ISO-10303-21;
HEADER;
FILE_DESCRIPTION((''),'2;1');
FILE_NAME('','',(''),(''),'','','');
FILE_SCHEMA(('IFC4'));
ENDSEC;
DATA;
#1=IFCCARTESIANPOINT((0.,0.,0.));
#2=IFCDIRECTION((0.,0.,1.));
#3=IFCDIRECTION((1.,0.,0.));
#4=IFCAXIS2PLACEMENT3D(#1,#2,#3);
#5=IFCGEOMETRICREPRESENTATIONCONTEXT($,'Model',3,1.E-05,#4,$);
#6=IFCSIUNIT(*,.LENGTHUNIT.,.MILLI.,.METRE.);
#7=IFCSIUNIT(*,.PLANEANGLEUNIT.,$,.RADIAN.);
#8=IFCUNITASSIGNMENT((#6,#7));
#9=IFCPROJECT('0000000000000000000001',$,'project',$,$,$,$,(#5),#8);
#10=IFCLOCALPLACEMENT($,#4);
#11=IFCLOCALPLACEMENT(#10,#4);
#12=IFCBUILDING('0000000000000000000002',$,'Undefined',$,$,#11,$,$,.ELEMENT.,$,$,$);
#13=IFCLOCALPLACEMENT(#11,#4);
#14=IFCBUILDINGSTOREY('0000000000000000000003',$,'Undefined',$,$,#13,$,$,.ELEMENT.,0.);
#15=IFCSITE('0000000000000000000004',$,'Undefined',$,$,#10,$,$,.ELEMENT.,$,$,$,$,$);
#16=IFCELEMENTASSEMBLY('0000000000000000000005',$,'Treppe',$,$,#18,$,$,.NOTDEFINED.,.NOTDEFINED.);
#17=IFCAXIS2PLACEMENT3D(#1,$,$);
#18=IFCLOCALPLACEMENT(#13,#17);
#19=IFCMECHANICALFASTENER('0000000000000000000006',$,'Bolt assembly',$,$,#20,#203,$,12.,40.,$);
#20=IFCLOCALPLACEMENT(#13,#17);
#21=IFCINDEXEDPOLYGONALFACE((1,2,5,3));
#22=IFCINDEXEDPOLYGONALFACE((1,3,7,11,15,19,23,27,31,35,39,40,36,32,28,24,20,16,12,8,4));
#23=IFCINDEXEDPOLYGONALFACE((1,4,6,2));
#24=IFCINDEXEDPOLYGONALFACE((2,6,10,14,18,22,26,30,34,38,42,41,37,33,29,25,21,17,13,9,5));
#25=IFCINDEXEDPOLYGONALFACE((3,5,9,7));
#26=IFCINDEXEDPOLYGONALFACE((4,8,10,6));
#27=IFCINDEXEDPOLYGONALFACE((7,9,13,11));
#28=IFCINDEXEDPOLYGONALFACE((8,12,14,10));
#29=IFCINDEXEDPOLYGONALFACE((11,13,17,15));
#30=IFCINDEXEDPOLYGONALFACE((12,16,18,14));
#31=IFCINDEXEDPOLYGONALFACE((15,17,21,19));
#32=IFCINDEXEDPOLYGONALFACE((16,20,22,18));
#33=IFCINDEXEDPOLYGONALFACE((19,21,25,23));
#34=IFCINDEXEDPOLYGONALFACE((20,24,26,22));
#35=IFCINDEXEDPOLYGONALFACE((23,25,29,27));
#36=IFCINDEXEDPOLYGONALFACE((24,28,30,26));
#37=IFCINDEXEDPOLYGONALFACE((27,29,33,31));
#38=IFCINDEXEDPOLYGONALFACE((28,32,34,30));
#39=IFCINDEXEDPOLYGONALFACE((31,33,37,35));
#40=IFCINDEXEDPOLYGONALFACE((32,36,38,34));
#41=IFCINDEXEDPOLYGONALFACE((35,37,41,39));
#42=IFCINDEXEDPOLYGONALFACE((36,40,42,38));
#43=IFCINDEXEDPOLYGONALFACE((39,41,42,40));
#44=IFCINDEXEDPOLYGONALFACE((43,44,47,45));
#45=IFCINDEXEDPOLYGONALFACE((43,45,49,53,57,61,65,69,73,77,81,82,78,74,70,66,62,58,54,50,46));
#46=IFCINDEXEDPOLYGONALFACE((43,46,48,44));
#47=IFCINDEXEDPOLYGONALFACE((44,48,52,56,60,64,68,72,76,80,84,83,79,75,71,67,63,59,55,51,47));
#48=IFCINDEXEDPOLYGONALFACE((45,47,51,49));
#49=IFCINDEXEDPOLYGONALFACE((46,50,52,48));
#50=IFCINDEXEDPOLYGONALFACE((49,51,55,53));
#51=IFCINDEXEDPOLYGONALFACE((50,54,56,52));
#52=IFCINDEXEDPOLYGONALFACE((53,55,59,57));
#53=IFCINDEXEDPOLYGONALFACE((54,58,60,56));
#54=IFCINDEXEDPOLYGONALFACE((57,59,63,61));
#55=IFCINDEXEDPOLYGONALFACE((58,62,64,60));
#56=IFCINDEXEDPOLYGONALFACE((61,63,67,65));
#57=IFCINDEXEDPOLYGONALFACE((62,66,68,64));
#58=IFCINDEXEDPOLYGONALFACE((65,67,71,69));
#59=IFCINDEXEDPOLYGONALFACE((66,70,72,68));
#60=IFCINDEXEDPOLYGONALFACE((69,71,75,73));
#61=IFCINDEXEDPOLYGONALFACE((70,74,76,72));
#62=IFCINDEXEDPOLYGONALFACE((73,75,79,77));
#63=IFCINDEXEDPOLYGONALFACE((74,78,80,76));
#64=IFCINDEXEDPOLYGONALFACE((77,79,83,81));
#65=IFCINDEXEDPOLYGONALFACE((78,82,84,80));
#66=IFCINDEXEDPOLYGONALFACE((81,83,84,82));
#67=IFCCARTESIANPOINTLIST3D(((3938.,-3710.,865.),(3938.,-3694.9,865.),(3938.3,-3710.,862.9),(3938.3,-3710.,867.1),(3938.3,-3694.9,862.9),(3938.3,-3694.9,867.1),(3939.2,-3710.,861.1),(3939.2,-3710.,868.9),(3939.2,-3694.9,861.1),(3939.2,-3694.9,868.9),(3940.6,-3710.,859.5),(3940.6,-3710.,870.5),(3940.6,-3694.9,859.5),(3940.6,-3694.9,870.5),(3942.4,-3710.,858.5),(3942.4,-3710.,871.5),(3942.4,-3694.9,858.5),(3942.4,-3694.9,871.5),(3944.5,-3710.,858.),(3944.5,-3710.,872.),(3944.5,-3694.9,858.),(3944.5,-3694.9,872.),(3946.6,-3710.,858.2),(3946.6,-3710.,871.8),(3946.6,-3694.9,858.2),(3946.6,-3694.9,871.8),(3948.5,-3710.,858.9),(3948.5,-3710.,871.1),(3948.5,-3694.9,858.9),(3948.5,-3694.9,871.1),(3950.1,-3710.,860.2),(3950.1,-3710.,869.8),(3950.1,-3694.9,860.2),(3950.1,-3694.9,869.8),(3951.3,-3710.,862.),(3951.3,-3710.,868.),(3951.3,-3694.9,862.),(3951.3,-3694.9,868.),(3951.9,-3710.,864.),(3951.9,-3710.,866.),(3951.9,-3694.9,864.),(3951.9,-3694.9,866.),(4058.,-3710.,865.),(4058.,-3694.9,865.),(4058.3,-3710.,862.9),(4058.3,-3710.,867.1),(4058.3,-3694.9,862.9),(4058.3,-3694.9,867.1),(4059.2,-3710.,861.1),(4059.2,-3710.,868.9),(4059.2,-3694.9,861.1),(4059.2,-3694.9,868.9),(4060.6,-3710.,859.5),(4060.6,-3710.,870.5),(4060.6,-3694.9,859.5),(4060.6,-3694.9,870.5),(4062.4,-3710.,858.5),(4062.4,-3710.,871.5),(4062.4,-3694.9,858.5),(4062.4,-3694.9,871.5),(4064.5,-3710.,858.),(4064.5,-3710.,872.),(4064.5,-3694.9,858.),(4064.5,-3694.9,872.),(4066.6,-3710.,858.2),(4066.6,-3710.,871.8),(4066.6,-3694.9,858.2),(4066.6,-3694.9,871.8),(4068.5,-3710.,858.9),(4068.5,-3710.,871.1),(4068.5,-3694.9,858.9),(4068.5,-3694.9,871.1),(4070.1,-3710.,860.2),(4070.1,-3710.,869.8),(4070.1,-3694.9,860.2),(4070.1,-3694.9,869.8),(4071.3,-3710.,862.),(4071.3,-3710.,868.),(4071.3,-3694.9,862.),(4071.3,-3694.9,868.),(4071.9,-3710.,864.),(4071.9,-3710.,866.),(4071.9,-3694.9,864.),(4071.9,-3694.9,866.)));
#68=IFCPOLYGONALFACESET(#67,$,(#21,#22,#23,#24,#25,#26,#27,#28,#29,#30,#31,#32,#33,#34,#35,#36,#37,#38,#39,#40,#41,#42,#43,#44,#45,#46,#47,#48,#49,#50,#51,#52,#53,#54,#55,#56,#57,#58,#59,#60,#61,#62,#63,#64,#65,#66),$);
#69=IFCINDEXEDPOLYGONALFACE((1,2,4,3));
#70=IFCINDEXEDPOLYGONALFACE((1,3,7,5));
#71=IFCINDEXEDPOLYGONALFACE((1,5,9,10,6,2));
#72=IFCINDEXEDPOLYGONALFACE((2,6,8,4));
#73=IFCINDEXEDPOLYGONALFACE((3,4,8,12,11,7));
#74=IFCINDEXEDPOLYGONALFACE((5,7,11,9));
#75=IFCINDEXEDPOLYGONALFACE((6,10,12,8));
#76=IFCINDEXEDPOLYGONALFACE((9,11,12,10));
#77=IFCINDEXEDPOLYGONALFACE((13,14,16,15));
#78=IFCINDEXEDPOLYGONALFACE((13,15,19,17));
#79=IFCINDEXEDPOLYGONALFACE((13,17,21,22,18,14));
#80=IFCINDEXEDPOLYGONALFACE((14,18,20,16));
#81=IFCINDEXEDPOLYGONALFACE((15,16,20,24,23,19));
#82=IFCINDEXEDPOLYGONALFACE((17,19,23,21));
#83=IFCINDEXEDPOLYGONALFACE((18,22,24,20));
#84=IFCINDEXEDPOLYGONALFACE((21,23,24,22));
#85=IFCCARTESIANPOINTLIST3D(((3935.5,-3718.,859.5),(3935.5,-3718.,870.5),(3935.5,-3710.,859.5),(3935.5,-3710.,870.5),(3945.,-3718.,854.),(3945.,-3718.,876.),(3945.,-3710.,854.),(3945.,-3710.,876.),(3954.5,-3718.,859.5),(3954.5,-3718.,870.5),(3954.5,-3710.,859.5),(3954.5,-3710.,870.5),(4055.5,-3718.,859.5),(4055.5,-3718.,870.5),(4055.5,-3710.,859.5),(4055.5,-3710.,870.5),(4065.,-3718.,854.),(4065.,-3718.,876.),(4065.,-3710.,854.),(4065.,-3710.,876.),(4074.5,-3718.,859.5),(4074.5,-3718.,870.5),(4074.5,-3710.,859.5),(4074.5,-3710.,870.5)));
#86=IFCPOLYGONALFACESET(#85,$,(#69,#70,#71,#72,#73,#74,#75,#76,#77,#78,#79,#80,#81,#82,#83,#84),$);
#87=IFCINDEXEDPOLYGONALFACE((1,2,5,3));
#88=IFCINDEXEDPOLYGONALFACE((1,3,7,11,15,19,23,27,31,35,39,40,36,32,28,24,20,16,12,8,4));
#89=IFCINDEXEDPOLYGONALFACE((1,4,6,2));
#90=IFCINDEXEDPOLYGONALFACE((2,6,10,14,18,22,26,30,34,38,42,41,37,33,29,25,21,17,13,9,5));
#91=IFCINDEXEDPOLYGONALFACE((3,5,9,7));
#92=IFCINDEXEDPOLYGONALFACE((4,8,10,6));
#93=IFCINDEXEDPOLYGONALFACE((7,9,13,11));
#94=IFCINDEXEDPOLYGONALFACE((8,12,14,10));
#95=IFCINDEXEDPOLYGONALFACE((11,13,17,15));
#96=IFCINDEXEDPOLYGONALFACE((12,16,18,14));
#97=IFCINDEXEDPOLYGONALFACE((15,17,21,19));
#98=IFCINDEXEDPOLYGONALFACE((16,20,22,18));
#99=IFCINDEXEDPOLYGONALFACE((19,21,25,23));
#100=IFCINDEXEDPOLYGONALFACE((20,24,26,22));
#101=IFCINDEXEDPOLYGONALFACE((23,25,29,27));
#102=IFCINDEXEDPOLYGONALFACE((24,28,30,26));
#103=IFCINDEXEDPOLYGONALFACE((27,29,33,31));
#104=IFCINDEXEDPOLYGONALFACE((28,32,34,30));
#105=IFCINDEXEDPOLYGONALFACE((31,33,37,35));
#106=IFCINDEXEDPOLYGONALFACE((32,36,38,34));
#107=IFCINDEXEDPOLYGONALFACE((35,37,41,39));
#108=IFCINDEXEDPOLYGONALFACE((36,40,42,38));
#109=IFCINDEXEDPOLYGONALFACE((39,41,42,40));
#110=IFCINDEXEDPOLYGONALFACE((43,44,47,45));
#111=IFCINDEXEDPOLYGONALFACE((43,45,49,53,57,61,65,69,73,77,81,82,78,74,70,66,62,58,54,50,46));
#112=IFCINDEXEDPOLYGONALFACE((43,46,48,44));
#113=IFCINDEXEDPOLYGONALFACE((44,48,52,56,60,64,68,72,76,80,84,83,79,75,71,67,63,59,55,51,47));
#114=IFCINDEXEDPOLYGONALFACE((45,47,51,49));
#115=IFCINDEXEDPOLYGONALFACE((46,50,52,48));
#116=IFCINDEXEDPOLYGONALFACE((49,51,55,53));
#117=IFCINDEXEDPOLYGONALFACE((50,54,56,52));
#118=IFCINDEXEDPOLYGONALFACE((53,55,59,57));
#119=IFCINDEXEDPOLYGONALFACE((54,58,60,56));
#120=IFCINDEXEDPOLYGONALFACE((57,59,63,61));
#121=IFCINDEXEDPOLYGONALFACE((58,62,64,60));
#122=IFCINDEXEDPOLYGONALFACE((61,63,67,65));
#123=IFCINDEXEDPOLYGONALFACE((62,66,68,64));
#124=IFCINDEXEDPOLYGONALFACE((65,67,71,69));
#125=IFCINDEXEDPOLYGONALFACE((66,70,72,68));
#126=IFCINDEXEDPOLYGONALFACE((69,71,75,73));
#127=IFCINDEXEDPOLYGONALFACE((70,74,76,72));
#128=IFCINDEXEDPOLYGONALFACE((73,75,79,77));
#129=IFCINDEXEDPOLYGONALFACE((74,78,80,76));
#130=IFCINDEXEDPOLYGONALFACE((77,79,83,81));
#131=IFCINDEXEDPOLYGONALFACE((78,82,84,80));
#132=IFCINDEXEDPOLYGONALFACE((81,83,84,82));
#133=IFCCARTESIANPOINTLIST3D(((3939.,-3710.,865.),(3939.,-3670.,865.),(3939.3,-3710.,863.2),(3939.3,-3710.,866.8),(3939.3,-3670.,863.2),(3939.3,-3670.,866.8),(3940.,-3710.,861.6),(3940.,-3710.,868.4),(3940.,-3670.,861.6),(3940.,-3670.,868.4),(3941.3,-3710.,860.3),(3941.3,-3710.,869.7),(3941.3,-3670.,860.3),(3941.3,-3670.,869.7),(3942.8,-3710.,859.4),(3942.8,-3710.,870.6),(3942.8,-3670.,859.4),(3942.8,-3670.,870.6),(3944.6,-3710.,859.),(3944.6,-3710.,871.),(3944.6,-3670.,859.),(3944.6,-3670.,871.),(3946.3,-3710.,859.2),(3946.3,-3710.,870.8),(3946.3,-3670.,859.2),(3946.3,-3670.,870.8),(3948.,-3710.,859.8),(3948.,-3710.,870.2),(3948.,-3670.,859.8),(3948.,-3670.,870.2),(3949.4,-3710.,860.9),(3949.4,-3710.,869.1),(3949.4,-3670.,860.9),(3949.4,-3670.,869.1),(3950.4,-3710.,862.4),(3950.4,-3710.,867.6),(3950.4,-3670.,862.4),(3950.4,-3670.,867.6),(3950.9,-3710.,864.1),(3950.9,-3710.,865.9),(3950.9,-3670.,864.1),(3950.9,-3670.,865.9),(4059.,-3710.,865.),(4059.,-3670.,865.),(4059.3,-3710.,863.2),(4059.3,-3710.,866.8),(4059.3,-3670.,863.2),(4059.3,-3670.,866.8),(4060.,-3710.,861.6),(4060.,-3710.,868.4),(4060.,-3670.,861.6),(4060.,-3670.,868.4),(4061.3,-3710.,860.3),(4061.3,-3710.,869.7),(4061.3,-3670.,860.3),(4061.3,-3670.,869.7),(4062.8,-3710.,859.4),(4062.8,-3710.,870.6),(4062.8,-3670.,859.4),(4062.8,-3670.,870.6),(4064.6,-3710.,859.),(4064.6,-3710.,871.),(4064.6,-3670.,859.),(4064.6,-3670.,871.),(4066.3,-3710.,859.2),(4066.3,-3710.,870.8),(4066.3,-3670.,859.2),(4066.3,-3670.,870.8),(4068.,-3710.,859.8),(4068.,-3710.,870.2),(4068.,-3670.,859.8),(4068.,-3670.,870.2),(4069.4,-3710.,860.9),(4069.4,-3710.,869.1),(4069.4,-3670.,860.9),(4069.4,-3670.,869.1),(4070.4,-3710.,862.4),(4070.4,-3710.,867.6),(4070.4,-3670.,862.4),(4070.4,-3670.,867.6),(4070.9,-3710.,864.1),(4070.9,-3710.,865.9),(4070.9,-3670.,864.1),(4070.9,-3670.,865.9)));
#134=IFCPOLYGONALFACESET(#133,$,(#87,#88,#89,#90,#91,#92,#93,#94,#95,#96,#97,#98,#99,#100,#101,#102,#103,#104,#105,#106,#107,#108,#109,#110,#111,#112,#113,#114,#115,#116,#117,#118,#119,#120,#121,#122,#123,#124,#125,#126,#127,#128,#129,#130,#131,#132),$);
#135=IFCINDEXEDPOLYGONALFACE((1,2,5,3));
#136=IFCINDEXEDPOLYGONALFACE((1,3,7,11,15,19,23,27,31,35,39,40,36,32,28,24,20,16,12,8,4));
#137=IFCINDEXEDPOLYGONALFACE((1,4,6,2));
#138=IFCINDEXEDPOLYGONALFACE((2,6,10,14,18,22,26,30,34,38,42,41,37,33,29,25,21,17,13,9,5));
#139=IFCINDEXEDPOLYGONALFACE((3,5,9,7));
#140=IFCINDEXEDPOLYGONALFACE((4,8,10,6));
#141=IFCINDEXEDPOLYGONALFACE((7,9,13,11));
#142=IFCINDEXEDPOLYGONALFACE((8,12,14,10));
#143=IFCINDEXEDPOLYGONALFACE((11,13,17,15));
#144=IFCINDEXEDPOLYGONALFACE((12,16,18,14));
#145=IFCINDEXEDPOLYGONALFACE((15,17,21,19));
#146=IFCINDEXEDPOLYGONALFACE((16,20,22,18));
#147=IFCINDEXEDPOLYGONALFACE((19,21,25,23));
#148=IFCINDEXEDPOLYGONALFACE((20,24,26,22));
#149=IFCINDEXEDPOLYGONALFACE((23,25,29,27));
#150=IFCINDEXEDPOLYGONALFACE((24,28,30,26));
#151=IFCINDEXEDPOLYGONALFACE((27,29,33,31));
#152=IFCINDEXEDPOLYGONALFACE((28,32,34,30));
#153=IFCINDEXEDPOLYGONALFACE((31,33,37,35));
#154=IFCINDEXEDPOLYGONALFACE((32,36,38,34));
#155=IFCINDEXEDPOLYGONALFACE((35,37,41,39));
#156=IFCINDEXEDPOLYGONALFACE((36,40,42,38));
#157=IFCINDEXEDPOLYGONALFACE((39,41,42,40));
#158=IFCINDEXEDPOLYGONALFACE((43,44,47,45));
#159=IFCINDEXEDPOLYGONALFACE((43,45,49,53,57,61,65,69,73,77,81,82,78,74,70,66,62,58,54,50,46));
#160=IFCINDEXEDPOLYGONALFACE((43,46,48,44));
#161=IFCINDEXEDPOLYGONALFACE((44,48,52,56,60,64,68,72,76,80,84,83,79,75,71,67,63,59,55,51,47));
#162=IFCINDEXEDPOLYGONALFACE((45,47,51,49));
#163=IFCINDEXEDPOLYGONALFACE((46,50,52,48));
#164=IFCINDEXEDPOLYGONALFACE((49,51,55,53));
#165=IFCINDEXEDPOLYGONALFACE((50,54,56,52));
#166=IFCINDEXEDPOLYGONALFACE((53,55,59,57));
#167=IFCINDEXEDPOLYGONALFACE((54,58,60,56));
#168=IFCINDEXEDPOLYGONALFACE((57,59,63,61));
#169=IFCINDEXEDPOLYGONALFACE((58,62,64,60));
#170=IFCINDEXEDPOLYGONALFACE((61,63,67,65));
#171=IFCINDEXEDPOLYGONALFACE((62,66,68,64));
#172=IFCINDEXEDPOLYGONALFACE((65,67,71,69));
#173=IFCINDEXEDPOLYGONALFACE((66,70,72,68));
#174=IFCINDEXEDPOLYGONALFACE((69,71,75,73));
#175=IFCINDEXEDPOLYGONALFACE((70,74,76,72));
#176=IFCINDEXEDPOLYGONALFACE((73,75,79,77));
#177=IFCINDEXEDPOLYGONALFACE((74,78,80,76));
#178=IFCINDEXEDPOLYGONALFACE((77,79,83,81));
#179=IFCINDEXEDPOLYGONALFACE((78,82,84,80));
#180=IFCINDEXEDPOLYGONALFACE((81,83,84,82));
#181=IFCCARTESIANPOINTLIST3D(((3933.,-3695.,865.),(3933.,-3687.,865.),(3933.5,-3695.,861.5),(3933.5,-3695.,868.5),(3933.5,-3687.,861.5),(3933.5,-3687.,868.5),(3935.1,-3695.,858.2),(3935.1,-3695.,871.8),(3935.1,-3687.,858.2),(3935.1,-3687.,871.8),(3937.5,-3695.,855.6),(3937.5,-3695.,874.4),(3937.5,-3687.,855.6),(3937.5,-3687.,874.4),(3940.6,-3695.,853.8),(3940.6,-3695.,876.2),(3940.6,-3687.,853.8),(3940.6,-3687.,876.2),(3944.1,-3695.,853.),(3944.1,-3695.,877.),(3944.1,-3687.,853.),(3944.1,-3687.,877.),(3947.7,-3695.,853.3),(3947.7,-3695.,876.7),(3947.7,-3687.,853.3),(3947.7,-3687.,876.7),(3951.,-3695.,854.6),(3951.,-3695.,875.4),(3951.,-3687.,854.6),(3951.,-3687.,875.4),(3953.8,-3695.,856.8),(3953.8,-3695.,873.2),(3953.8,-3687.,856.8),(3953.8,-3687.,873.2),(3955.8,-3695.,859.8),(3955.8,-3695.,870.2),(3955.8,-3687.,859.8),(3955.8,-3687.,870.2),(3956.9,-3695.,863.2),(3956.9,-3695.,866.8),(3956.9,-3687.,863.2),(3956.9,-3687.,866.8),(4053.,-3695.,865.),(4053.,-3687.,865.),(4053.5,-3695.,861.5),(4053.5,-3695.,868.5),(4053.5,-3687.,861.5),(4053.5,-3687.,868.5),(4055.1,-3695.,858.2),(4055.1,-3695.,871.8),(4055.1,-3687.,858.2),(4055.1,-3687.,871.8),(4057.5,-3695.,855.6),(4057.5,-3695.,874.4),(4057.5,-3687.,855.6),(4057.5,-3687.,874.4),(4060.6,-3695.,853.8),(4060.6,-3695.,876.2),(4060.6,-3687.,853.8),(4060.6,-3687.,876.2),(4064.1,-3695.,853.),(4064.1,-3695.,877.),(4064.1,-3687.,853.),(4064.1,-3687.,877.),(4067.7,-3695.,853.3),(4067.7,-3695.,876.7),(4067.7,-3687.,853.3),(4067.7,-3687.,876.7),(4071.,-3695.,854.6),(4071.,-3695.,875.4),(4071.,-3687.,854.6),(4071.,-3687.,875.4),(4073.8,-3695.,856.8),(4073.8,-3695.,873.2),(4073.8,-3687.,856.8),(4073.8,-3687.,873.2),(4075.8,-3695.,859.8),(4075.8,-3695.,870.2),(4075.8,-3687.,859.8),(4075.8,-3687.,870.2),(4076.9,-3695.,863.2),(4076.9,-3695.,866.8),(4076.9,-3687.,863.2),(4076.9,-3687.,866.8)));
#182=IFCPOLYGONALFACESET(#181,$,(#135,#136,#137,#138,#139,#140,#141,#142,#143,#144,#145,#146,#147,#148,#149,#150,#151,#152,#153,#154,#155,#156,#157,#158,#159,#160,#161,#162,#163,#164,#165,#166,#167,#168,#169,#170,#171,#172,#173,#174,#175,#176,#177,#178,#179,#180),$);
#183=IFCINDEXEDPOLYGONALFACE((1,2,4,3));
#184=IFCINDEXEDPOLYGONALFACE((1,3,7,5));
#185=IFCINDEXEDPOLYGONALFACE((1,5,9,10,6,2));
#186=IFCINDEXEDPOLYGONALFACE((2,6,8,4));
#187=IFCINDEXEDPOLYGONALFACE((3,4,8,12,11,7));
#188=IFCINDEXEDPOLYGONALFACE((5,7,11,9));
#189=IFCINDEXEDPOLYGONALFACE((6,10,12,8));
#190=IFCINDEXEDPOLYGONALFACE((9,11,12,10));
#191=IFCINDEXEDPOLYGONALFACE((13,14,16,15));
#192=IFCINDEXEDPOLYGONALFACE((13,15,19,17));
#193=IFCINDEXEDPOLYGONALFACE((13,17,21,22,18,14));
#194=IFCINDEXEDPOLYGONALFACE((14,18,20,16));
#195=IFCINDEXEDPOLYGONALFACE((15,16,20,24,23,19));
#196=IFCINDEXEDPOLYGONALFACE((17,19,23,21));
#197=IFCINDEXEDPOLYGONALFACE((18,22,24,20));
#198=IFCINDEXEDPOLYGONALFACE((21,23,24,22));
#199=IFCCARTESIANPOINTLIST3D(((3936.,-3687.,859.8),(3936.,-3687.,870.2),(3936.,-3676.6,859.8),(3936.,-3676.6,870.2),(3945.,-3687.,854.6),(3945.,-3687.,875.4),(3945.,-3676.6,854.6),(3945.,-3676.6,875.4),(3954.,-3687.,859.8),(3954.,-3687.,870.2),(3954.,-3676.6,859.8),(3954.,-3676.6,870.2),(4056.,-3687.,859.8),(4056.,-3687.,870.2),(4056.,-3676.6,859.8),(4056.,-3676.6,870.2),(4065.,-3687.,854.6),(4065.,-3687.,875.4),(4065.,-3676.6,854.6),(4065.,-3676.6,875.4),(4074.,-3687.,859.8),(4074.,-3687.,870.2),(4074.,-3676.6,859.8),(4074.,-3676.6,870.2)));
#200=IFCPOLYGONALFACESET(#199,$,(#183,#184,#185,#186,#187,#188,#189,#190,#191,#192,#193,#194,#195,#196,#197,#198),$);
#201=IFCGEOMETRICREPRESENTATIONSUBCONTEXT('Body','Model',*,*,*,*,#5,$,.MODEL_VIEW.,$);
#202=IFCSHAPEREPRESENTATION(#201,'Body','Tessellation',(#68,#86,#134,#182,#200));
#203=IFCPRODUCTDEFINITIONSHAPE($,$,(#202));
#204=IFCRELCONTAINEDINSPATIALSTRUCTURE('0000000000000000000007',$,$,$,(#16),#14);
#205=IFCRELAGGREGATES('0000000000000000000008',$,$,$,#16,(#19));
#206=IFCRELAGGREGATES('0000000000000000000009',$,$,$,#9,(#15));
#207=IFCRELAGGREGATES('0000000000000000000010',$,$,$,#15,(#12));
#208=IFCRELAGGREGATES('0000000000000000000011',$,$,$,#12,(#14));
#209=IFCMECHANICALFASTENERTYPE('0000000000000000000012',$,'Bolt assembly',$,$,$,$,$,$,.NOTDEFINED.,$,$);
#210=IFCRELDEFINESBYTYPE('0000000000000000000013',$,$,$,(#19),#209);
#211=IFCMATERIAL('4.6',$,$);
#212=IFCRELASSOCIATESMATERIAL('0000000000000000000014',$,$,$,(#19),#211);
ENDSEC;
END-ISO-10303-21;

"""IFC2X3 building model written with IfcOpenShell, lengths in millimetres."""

from ifc_helpers import new_model, si_unit, frame, origin_with_axes, origin_2d_with_axis, place, context, subcontext, project, spatial, polyline, circle, outline, extrude, source, transform, mapped, material, type_object, element, aggregate, save


model = new_model("IFC2X3")

# Units and contexts
model_context = context("Model", 3, precision=1e-05, world=origin_with_axes())
body_context = subcontext(model_context, "Body", "Model", "MODEL_VIEW")
ifc_project = project(units=[si_unit("LENGTHUNIT", "METRE", prefix="MILLI"), si_unit("PLANEANGLEUNIT", "RADIAN")], contexts=[model_context])

# Site, building, storey
site_placement = place(None, origin_with_axes())
site = spatial("IfcSite", under=ifc_project, at=site_placement, Name="Undefined", CompositionType="ELEMENT")
building_placement = place(site_placement, origin_with_axes())
building = spatial("IfcBuilding", under=site, at=building_placement, Name="Undefined", CompositionType="ELEMENT")
storey_placement = place(building_placement, origin_with_axes())
storey = spatial("IfcBuildingStorey", under=building, at=storey_placement, Name="Undefined", CompositionType="ELEMENT", Elevation=0.0)

# Element assembly, mechanical fastener
assembly_1_placement = place(storey_placement, origin_with_axes())
assembly_1 = element("IfcElementAssembly", 1, at=assembly_1_placement, inside=storey, Name="Treppe", AssemblyPlace="NOTDEFINED", PredefinedType="NOTDEFINED")
ifc_material_1 = material(Name="4.6")
mechanical_fastener_type = type_object("IfcMechanicalFastenerType", Name="Bolt assembly")
shared_shape_1 = source(origin_with_axes(), body_context, "Body", "SweptSolid", [
    extrude(circle(Radius=7.0, at=origin_2d_with_axis()), frame((0.0, 0.0, 0.0), z_axis=(0.0, 1.0, 0.0), x_axis=(1.0, 0.0, 0.0)), (0.0, 0.0, 1.0), 15.1),
    extrude(outline(polyline([(9.5, -5.5), (9.5, 5.5), (0.0, 11.0), (-9.5, 5.5), (-9.5, -5.5), (0.0, -11.0), (9.5, -5.5)])), frame((0.0, -8.0, 0.0), z_axis=(0.0, 1.0, 0.0), x_axis=(1.0, 0.0, 0.0)), (0.0, 0.0, 1.0), 8.0),
    extrude(circle(Radius=6.0, at=origin_2d_with_axis()), frame((0.0, 0.0, 0.0), z_axis=(0.0, 1.0, 0.0), x_axis=(1.0, 0.0, 0.0)), (0.0, 0.0, 1.0), 40.0),
    extrude(circle(Radius=12.0, at=origin_2d_with_axis()), frame((0.0, 15.0, 0.0), z_axis=(0.0, 1.0, 0.0), x_axis=(1.0, 0.0, 0.0)), (0.0, 0.0, 1.0), 8.0),
    extrude(outline(polyline([(9.0, -5.2), (9.0, 5.2), (0.0, 10.4), (-9.0, 5.2), (-9.0, -5.2), (0.0, -10.4), (9.0, -5.2)])), frame((0.0, 23.0, 0.0), z_axis=(0.0, 1.0, 0.0), x_axis=(1.0, 0.0, 0.0)), (0.0, 0.0, 1.0), 10.4),
])
mechanical_fastener_1_placement = place(assembly_1_placement, frame((4065.0, -3710.0, 865.0), z_axis=(0.0, 0.0, -1.0), x_axis=(-1.0, 0.0, 0.0)))
mechanical_fastener_1 = element("IfcMechanicalFastener", 2, at=mechanical_fastener_1_placement, type_object=mechanical_fastener_type, material=ifc_material_1, Name="Bolt assembly", NominalDiameter=12.0, NominalLength=40.0, context=body_context, shape_type="MappedRepresentation", body=[
    mapped(shared_shape_1, transform((0.0, 0.0, 0.0))),
    mapped(shared_shape_1, transform((120.0, 0.0, 0.0))),
])
aggregate(assembly_1, [mechanical_fastener_1])

save(model, "model.ifc")
